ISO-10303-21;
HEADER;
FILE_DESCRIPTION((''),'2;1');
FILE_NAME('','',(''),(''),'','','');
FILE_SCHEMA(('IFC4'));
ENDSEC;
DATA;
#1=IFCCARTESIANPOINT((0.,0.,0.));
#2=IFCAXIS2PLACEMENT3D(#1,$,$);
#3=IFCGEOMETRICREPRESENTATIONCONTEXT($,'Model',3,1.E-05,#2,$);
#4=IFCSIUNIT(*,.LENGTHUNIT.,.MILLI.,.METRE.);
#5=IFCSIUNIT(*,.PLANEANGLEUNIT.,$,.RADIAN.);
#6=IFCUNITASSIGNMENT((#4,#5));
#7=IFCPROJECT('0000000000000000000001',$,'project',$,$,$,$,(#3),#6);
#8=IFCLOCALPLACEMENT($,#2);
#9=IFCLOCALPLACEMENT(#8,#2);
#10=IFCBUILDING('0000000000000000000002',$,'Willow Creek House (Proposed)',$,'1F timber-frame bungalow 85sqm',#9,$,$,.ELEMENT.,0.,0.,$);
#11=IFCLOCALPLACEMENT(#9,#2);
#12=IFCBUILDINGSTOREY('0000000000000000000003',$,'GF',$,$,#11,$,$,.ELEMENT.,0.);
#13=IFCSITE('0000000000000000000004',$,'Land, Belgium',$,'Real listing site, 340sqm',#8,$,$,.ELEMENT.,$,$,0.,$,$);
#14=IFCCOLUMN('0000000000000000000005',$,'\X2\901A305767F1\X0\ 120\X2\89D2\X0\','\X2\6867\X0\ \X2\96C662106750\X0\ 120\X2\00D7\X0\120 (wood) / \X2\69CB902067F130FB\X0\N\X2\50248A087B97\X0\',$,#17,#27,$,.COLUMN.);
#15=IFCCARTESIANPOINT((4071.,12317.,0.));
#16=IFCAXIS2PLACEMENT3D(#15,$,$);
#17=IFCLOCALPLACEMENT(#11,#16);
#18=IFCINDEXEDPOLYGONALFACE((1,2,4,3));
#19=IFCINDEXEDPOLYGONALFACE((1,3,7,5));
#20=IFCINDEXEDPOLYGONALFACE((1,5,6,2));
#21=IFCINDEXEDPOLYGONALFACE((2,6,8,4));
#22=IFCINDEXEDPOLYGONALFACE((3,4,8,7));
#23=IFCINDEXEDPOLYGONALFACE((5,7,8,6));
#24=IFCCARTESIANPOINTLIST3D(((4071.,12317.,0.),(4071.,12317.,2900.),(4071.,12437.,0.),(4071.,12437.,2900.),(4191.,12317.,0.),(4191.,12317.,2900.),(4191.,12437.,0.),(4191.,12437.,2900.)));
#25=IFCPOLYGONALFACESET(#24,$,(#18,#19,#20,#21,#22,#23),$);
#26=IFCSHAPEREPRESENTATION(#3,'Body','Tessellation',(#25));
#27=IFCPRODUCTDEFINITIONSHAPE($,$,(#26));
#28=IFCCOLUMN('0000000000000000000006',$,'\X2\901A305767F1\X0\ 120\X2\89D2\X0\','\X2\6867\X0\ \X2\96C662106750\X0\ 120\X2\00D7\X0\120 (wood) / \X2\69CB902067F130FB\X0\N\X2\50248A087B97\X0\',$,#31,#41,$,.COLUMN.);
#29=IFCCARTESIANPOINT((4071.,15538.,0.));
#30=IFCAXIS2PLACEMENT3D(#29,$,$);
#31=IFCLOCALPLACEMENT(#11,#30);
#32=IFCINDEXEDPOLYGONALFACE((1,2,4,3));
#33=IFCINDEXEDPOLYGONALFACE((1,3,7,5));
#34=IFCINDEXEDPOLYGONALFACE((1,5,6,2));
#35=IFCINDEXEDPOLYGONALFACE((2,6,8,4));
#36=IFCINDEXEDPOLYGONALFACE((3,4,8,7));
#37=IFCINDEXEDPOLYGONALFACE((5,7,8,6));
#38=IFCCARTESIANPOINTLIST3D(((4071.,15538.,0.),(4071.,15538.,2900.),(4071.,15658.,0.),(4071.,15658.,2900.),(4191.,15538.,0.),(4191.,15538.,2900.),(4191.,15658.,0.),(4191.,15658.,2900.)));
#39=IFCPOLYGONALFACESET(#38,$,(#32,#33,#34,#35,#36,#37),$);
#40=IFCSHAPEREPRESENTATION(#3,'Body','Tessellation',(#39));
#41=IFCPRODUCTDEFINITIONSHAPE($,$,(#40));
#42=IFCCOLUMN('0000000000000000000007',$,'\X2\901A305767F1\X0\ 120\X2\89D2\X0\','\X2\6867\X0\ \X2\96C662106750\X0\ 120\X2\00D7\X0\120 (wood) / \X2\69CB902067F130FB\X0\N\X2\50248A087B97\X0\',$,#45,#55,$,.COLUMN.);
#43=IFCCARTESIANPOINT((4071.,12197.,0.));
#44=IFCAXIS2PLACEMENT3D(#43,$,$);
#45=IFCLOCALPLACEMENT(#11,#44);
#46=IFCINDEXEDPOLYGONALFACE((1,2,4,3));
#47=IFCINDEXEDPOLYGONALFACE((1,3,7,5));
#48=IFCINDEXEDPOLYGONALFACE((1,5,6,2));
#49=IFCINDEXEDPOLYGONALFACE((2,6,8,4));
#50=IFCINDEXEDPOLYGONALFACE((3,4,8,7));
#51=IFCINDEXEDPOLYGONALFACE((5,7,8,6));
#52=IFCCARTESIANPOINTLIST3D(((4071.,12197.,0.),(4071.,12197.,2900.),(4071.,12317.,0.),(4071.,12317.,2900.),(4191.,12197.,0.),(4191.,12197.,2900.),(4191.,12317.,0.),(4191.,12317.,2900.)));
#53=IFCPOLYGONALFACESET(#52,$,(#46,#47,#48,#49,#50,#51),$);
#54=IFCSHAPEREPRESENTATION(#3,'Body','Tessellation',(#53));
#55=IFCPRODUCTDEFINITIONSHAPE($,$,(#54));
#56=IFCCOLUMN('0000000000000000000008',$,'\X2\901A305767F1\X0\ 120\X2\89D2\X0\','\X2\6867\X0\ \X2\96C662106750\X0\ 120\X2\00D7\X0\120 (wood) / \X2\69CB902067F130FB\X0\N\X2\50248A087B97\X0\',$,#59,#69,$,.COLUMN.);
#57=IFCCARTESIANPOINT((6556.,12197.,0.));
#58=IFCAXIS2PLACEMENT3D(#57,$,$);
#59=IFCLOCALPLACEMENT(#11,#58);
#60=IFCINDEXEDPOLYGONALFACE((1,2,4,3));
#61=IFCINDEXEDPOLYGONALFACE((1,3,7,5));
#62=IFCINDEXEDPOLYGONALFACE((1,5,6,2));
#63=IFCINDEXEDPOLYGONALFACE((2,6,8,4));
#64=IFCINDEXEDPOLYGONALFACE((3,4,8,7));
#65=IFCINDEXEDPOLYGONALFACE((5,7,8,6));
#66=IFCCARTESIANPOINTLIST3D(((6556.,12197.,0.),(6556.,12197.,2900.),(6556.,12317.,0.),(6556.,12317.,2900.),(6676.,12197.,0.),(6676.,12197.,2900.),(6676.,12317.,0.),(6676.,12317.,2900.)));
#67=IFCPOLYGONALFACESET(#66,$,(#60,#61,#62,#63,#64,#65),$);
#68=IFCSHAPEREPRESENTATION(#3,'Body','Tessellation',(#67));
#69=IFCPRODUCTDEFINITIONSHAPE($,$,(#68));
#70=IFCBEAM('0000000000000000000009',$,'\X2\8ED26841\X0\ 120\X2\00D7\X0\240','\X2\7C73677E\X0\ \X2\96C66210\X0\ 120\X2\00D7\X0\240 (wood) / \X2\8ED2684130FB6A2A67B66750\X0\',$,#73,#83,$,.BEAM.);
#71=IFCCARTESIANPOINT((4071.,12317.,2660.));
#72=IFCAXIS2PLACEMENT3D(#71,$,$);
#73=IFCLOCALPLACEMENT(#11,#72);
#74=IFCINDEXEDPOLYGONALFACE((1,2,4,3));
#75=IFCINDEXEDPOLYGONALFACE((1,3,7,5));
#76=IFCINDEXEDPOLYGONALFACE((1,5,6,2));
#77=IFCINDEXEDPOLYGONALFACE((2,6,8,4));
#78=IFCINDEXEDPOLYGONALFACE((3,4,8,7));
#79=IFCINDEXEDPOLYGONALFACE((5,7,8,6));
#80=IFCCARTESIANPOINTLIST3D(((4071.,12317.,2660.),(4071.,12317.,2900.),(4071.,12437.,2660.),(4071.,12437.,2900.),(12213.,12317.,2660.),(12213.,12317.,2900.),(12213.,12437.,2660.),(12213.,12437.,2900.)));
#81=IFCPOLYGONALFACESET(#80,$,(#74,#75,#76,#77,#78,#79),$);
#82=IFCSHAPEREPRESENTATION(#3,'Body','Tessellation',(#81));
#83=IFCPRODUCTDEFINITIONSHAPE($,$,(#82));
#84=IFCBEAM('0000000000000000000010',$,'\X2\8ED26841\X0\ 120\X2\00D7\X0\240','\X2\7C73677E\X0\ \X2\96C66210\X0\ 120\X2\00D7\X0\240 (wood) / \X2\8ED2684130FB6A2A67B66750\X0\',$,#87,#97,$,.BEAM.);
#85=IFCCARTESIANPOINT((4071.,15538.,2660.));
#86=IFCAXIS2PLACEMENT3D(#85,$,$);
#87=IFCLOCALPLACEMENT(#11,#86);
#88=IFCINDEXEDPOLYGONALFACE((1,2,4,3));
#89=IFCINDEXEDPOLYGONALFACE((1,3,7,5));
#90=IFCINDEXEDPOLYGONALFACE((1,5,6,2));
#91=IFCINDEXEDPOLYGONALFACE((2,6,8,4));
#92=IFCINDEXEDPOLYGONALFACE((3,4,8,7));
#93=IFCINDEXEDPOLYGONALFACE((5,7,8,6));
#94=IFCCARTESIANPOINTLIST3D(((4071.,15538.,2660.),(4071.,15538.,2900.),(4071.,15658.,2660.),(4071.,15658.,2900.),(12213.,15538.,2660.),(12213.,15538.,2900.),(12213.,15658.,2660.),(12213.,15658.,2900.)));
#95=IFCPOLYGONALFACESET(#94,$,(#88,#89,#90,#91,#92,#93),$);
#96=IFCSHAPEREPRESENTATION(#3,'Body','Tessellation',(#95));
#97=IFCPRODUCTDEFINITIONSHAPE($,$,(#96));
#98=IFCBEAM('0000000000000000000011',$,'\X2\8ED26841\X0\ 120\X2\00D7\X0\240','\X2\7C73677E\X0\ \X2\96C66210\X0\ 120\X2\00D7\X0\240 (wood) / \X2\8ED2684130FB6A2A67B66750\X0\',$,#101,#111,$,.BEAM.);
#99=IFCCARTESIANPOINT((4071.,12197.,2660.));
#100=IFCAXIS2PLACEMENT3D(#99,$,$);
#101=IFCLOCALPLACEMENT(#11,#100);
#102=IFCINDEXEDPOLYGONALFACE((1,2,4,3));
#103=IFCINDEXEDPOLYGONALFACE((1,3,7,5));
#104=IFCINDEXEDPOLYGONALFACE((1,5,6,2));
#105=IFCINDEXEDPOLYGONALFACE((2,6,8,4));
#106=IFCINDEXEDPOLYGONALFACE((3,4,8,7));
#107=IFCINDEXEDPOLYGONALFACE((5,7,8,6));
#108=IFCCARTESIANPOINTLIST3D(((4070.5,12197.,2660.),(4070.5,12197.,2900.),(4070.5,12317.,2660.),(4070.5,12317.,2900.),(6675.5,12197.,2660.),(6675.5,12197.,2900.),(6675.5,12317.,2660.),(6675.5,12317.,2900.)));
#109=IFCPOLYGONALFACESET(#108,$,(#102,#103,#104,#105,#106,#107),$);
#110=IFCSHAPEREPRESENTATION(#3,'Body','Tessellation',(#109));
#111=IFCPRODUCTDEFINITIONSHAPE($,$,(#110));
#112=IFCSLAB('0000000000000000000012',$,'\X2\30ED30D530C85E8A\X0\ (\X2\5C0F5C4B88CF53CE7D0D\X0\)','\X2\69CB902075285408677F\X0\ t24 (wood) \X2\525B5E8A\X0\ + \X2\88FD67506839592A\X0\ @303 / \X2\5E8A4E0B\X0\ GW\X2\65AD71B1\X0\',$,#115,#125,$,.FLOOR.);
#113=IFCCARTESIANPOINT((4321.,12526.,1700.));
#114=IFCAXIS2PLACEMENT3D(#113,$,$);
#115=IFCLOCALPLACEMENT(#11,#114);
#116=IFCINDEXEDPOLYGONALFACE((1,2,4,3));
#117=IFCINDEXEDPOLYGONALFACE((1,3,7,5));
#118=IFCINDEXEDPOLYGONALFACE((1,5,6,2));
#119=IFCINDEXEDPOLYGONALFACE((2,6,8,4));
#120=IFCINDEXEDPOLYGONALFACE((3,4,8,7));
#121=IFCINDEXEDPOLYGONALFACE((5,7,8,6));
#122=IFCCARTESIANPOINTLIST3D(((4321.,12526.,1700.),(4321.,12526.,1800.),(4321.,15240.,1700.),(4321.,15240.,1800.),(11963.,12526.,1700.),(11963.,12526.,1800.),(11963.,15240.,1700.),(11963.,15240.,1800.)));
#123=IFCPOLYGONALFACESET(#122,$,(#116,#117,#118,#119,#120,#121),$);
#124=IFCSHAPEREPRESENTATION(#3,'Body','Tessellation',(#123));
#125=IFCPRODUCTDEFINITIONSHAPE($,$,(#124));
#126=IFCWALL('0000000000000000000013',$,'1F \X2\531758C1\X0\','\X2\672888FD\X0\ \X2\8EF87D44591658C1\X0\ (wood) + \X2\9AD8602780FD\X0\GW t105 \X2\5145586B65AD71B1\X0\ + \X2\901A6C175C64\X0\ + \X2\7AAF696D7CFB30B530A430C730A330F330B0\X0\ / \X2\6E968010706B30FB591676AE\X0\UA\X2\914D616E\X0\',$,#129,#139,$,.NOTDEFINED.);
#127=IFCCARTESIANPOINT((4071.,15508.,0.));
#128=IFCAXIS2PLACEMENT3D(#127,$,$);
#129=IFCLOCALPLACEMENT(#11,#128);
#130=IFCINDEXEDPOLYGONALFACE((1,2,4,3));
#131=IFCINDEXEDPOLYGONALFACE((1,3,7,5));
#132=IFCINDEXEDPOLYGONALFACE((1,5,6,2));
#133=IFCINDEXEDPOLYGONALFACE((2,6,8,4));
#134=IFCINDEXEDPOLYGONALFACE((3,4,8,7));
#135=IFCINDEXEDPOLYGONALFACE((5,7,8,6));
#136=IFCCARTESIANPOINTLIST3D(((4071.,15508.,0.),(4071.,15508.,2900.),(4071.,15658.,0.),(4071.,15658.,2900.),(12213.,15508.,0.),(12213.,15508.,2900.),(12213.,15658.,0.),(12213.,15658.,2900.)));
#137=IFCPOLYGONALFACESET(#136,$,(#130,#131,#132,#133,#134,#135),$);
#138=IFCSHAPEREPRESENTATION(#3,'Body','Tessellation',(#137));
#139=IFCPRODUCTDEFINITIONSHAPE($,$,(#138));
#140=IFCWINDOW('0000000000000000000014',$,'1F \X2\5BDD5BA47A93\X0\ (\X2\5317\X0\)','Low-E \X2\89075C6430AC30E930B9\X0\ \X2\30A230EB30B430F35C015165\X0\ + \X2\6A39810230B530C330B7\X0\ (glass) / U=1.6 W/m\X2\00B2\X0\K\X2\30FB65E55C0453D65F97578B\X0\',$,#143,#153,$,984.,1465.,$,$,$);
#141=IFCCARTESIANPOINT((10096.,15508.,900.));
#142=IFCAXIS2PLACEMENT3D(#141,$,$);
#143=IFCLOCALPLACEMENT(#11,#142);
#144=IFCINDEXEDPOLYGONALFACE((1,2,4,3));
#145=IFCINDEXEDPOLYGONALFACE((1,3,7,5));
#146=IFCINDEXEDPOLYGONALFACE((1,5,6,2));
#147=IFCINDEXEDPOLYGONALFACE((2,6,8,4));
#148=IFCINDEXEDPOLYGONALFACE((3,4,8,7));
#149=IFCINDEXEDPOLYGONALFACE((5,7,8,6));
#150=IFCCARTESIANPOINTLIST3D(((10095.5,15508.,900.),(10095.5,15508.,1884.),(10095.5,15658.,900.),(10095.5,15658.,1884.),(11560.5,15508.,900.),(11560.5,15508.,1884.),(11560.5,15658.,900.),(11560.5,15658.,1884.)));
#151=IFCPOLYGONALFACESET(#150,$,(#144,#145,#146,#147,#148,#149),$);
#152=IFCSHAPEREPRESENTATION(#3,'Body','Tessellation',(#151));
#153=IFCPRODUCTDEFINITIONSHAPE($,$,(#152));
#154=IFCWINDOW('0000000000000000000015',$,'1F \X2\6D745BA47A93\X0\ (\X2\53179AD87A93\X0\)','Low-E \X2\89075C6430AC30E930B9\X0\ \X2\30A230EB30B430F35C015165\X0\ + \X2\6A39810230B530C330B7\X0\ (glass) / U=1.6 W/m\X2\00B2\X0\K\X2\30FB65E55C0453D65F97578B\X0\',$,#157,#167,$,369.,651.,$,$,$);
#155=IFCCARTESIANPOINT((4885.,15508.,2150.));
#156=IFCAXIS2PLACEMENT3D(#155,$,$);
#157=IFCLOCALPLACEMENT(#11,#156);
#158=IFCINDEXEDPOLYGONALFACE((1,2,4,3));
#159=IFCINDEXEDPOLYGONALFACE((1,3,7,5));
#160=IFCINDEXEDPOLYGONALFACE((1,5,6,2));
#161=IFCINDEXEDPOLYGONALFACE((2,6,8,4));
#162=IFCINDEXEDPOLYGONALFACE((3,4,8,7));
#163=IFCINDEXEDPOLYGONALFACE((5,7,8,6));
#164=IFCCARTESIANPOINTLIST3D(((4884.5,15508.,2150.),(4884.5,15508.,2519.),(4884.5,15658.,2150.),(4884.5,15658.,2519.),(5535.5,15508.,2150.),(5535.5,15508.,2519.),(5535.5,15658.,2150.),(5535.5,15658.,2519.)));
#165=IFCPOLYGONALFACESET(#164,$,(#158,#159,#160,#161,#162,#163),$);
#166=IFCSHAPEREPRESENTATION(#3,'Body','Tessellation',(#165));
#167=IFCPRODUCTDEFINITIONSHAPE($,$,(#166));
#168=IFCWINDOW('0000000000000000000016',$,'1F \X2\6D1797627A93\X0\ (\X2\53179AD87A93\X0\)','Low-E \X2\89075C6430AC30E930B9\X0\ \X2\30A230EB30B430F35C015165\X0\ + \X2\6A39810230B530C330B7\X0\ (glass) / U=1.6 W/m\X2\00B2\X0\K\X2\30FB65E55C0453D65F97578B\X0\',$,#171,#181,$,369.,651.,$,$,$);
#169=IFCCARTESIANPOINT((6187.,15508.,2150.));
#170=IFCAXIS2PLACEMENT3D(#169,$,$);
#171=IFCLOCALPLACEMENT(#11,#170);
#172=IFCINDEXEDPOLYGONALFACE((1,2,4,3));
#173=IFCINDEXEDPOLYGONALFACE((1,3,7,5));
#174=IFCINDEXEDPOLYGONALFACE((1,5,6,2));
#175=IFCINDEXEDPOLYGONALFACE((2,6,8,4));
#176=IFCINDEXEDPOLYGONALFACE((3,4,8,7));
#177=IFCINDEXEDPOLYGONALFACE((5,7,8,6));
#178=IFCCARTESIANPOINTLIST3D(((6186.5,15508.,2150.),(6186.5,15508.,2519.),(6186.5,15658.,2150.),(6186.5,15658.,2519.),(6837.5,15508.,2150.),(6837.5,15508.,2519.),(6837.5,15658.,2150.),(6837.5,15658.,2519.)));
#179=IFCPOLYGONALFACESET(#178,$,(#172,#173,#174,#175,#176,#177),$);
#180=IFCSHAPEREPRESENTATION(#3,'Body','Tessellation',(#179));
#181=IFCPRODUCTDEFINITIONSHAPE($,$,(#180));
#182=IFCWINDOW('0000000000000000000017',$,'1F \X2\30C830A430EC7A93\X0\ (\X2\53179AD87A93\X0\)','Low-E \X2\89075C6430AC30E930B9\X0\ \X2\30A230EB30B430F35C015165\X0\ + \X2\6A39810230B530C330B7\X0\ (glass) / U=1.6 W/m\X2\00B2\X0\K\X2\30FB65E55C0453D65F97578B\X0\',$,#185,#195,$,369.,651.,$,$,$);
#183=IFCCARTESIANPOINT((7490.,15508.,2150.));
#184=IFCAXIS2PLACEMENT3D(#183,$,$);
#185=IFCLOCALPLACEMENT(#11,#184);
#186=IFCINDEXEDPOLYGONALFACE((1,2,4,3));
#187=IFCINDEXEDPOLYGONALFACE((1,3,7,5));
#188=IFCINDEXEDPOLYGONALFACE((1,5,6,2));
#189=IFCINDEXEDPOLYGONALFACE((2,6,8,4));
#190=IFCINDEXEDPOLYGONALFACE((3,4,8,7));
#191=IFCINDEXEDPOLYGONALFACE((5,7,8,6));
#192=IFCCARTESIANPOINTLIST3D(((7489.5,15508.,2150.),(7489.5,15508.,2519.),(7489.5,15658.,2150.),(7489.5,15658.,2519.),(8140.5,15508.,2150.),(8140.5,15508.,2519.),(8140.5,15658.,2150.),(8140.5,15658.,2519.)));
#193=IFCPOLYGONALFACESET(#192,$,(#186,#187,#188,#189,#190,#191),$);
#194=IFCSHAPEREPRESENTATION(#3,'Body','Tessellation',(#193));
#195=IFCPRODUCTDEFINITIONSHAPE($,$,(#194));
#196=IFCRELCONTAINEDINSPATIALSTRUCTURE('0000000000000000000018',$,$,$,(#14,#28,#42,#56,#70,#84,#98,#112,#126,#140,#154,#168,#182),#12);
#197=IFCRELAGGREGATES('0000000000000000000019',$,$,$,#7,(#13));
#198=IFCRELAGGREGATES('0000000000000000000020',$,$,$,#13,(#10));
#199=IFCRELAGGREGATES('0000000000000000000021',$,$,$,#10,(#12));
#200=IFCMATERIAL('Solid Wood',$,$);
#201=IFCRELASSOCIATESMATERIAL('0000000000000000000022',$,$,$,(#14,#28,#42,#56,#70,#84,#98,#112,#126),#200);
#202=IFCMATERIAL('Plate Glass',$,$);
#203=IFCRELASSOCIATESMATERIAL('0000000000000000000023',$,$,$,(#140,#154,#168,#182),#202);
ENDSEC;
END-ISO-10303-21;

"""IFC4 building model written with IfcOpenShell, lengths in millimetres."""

from ifc_helpers import new_model, si_unit, frame, frame_2d, origin, place, context, project, spatial, rectangle, extrude, material, element, fill, save


model = new_model("IFC4")

# Units and contexts
model_context = context("Model", 3, precision=1e-05, world=origin())
ifc_project = project(units=[si_unit("LENGTHUNIT", "METRE", prefix="MILLI"), si_unit("PLANEANGLEUNIT", "RADIAN")], contexts=[model_context])

# Site, building, storey
site_placement = place(None, origin())
site = spatial("IfcSite", under=ifc_project, at=site_placement, Name="Land, Belgium", ObjectType="Real listing site, 340sqm", CompositionType="ELEMENT", RefElevation=0.0)
building_placement = place(site_placement, origin())
building = spatial("IfcBuilding", under=site, at=building_placement, Name="Willow Creek House (Proposed)", ObjectType="1F timber-frame bungalow 85sqm", CompositionType="ELEMENT", ElevationOfRefHeight=0.0, ElevationOfTerrain=0.0)
storey_placement = place(building_placement, origin())
storey = spatial("IfcBuildingStorey", under=building, at=storey_placement, Name="GF", CompositionType="ELEMENT", Elevation=0.0)

# Columns
ifc_material_1 = material(Name="Solid Wood")
column_1_placement = place(storey_placement, frame((4071.0, 12317.0, 0.0)))
element("IfcColumn", 1, at=column_1_placement, inside=storey, material=ifc_material_1, Name="通し柱 120角", Description="桧 集成材 120×120 (wood) / 構造柱・N値計算", PredefinedType="COLUMN", context=model_context, shape_type="SweptSolid", body=[
    extrude(rectangle(XDim=120.0, YDim=120.0, at=frame_2d((60.0, 60.0))), frame((4071.0, 12317.0, 0.0)), (0.0, 0.0, 1.0), 2900.0),
])
column_2_placement = place(storey_placement, frame((4071.0, 15538.0, 0.0)))
element("IfcColumn", 2, at=column_2_placement, inside=storey, material=ifc_material_1, Name="通し柱 120角", Description="桧 集成材 120×120 (wood) / 構造柱・N値計算", PredefinedType="COLUMN", context=model_context, shape_type="SweptSolid", body=[
    extrude(rectangle(XDim=120.0, YDim=120.0, at=frame_2d((60.0, 60.0))), frame((4071.0, 15538.0, 0.0)), (0.0, 0.0, 1.0), 2900.0),
])
column_3_placement = place(storey_placement, frame((4071.0, 12197.0, 0.0)))
element("IfcColumn", 3, at=column_3_placement, inside=storey, material=ifc_material_1, Name="通し柱 120角", Description="桧 集成材 120×120 (wood) / 構造柱・N値計算", PredefinedType="COLUMN", context=model_context, shape_type="SweptSolid", body=[
    extrude(rectangle(XDim=120.0, YDim=120.0, at=frame_2d((60.0, 60.0))), frame((4071.0, 12197.0, 0.0)), (0.0, 0.0, 1.0), 2900.0),
])
column_4_placement = place(storey_placement, frame((6556.0, 12197.0, 0.0)))
element("IfcColumn", 4, at=column_4_placement, inside=storey, material=ifc_material_1, Name="通し柱 120角", Description="桧 集成材 120×120 (wood) / 構造柱・N値計算", PredefinedType="COLUMN", context=model_context, shape_type="SweptSolid", body=[
    extrude(rectangle(XDim=120.0, YDim=120.0, at=frame_2d((60.0, 60.0))), frame((6556.0, 12197.0, 0.0)), (0.0, 0.0, 1.0), 2900.0),
])

# Beams
beam_1_placement = place(storey_placement, frame((4071.0, 12317.0, 2660.0)))
element("IfcBeam", 5, at=beam_1_placement, inside=storey, material=ifc_material_1, Name="軒桁 120×240", Description="米松 集成 120×240 (wood) / 軒桁・横架材", PredefinedType="BEAM", context=model_context, shape_type="SweptSolid", body=[
    extrude(rectangle(XDim=8142.0, YDim=120.0, at=frame_2d((4071.0, 60.0))), frame((4071.0, 12317.0, 2660.0)), (0.0, 0.0, 1.0), 240.0),
])
beam_2_placement = place(storey_placement, frame((4071.0, 15538.0, 2660.0)))
element("IfcBeam", 6, at=beam_2_placement, inside=storey, material=ifc_material_1, Name="軒桁 120×240", Description="米松 集成 120×240 (wood) / 軒桁・横架材", PredefinedType="BEAM", context=model_context, shape_type="SweptSolid", body=[
    extrude(rectangle(XDim=8142.0, YDim=120.0, at=frame_2d((4071.0, 60.0))), frame((4071.0, 15538.0, 2660.0)), (0.0, 0.0, 1.0), 240.0),
])
beam_3_placement = place(storey_placement, frame((4071.0, 12197.0, 2660.0)))
element("IfcBeam", 7, at=beam_3_placement, inside=storey, material=ifc_material_1, Name="軒桁 120×240", Description="米松 集成 120×240 (wood) / 軒桁・横架材", PredefinedType="BEAM", context=model_context, shape_type="SweptSolid", body=[
    extrude(rectangle(XDim=2605.0, YDim=120.0, at=frame_2d((1302.0, 60.0))), frame((4071.0, 12197.0, 2660.0)), (0.0, 0.0, 1.0), 240.0),
])

# Slab
slab_1_placement = place(storey_placement, frame((4321.0, 12526.0, 1700.0)))
element("IfcSlab", 8, at=slab_1_placement, inside=storey, material=ifc_material_1, Name="ロフト床 (小屋裏収納)", Description="構造用合板 t24 (wood) 剛床 + 製材根太 @303 / 床下 GW断熱", PredefinedType="FLOOR", context=model_context, shape_type="SweptSolid", body=[
    extrude(rectangle(XDim=7642.0, YDim=2714.0, at=frame_2d((3821.0, 1357.0))), frame((4321.0, 12526.0, 1700.0)), (0.0, 0.0, 1.0), 100.0),
])

# Wall, openings, windows
wall_1_placement = place(storey_placement, frame((4071.0, 15508.0, 0.0)))
wall_1 = element("IfcWall", 9, at=wall_1_placement, inside=storey, material=ifc_material_1, Name="1F 北壁", Description="木製 軸組外壁 (wood) + 高性能GW t105 充填断熱 + 通気層 + 窯業系サイディング / 準耐火・外皮UA配慮", PredefinedType="NOTDEFINED", context=model_context, shape_type="SweptSolid", body=[
    extrude(rectangle(XDim=8142.0, YDim=150.0, at=frame_2d((4071.0, 75.0))), frame((4071.0, 15508.0, 0.0)), (0.0, 0.0, 1.0), 2900.0),
])
opening_1_placement = place(storey_placement, frame((10096.0, 15508.0, 900.0)))
opening_1 = element("IfcOpeningElement", 10, at=opening_1_placement, cuts=wall_1, PredefinedType="NOTDEFINED", context=model_context, shape_type="SweptSolid", body=[
    extrude(rectangle(XDim=1465.0, YDim=150.0, at=frame_2d((732.0, 75.0))), frame((10096.0, 15508.0, 900.0)), (0.0, 0.0, 1.0), 984.0),
])
opening_2_placement = place(storey_placement, frame((4885.0, 15508.0, 2150.0)))
opening_2 = element("IfcOpeningElement", 11, at=opening_2_placement, cuts=wall_1, PredefinedType="NOTDEFINED", context=model_context, shape_type="SweptSolid", body=[
    extrude(rectangle(XDim=651.0, YDim=150.0, at=frame_2d((325.0, 75.0))), frame((4885.0, 15508.0, 2150.0)), (0.0, 0.0, 1.0), 369.0),
])
opening_3_placement = place(storey_placement, frame((6187.0, 15508.0, 2150.0)))
opening_3 = element("IfcOpeningElement", 12, at=opening_3_placement, cuts=wall_1, PredefinedType="NOTDEFINED", context=model_context, shape_type="SweptSolid", body=[
    extrude(rectangle(XDim=651.0, YDim=150.0, at=frame_2d((325.0, 75.0))), frame((6187.0, 15508.0, 2150.0)), (0.0, 0.0, 1.0), 369.0),
])
opening_4_placement = place(storey_placement, frame((7490.0, 15508.0, 2150.0)))
opening_4 = element("IfcOpeningElement", 13, at=opening_4_placement, cuts=wall_1, PredefinedType="NOTDEFINED", context=model_context, shape_type="SweptSolid", body=[
    extrude(rectangle(XDim=651.0, YDim=150.0, at=frame_2d((325.0, 75.0))), frame((7490.0, 15508.0, 2150.0)), (0.0, 0.0, 1.0), 369.0),
])
ifc_material_2 = material(Name="Plate Glass")
window_1_placement = place(storey_placement, frame((10096.0, 15508.0, 900.0)))
window_1 = element("IfcWindow", 14, at=window_1_placement, inside=storey, material=ifc_material_2, Name="1F 寝室窓 (北)", Description="Low-E 複層ガラス アルゴン封入 + 樹脂サッシ (glass) / U=1.6 W/m²K・日射取得型", OverallHeight=984.0, OverallWidth=1465.0, context=model_context, shape_type="SweptSolid", body=[
    extrude(rectangle(XDim=1465.0, YDim=150.0, at=frame_2d((732.0, 75.0))), frame((10096.0, 15508.0, 900.0)), (0.0, 0.0, 1.0), 984.0),
])
fill(opening_1, window_1)
window_2_placement = place(storey_placement, frame((4885.0, 15508.0, 2150.0)))
window_2 = element("IfcWindow", 15, at=window_2_placement, inside=storey, material=ifc_material_2, Name="1F 浴室窓 (北高窓)", Description="Low-E 複層ガラス アルゴン封入 + 樹脂サッシ (glass) / U=1.6 W/m²K・日射取得型", OverallHeight=369.0, OverallWidth=651.0, context=model_context, shape_type="SweptSolid", body=[
    extrude(rectangle(XDim=651.0, YDim=150.0, at=frame_2d((325.0, 75.0))), frame((4885.0, 15508.0, 2150.0)), (0.0, 0.0, 1.0), 369.0),
])
fill(opening_2, window_2)
window_3_placement = place(storey_placement, frame((6187.0, 15508.0, 2150.0)))
window_3 = element("IfcWindow", 16, at=window_3_placement, inside=storey, material=ifc_material_2, Name="1F 洗面窓 (北高窓)", Description="Low-E 複層ガラス アルゴン封入 + 樹脂サッシ (glass) / U=1.6 W/m²K・日射取得型", OverallHeight=369.0, OverallWidth=651.0, context=model_context, shape_type="SweptSolid", body=[
    extrude(rectangle(XDim=651.0, YDim=150.0, at=frame_2d((325.0, 75.0))), frame((6187.0, 15508.0, 2150.0)), (0.0, 0.0, 1.0), 369.0),
])
fill(opening_3, window_3)
window_4_placement = place(storey_placement, frame((7490.0, 15508.0, 2150.0)))
window_4 = element("IfcWindow", 17, at=window_4_placement, inside=storey, material=ifc_material_2, Name="1F トイレ窓 (北高窓)", Description="Low-E 複層ガラス アルゴン封入 + 樹脂サッシ (glass) / U=1.6 W/m²K・日射取得型", OverallHeight=369.0, OverallWidth=651.0, context=model_context, shape_type="SweptSolid", body=[
    extrude(rectangle(XDim=651.0, YDim=150.0, at=frame_2d((325.0, 75.0))), frame((7490.0, 15508.0, 2150.0)), (0.0, 0.0, 1.0), 369.0),
])
fill(opening_4, window_4)

save(model, "model.ifc")
